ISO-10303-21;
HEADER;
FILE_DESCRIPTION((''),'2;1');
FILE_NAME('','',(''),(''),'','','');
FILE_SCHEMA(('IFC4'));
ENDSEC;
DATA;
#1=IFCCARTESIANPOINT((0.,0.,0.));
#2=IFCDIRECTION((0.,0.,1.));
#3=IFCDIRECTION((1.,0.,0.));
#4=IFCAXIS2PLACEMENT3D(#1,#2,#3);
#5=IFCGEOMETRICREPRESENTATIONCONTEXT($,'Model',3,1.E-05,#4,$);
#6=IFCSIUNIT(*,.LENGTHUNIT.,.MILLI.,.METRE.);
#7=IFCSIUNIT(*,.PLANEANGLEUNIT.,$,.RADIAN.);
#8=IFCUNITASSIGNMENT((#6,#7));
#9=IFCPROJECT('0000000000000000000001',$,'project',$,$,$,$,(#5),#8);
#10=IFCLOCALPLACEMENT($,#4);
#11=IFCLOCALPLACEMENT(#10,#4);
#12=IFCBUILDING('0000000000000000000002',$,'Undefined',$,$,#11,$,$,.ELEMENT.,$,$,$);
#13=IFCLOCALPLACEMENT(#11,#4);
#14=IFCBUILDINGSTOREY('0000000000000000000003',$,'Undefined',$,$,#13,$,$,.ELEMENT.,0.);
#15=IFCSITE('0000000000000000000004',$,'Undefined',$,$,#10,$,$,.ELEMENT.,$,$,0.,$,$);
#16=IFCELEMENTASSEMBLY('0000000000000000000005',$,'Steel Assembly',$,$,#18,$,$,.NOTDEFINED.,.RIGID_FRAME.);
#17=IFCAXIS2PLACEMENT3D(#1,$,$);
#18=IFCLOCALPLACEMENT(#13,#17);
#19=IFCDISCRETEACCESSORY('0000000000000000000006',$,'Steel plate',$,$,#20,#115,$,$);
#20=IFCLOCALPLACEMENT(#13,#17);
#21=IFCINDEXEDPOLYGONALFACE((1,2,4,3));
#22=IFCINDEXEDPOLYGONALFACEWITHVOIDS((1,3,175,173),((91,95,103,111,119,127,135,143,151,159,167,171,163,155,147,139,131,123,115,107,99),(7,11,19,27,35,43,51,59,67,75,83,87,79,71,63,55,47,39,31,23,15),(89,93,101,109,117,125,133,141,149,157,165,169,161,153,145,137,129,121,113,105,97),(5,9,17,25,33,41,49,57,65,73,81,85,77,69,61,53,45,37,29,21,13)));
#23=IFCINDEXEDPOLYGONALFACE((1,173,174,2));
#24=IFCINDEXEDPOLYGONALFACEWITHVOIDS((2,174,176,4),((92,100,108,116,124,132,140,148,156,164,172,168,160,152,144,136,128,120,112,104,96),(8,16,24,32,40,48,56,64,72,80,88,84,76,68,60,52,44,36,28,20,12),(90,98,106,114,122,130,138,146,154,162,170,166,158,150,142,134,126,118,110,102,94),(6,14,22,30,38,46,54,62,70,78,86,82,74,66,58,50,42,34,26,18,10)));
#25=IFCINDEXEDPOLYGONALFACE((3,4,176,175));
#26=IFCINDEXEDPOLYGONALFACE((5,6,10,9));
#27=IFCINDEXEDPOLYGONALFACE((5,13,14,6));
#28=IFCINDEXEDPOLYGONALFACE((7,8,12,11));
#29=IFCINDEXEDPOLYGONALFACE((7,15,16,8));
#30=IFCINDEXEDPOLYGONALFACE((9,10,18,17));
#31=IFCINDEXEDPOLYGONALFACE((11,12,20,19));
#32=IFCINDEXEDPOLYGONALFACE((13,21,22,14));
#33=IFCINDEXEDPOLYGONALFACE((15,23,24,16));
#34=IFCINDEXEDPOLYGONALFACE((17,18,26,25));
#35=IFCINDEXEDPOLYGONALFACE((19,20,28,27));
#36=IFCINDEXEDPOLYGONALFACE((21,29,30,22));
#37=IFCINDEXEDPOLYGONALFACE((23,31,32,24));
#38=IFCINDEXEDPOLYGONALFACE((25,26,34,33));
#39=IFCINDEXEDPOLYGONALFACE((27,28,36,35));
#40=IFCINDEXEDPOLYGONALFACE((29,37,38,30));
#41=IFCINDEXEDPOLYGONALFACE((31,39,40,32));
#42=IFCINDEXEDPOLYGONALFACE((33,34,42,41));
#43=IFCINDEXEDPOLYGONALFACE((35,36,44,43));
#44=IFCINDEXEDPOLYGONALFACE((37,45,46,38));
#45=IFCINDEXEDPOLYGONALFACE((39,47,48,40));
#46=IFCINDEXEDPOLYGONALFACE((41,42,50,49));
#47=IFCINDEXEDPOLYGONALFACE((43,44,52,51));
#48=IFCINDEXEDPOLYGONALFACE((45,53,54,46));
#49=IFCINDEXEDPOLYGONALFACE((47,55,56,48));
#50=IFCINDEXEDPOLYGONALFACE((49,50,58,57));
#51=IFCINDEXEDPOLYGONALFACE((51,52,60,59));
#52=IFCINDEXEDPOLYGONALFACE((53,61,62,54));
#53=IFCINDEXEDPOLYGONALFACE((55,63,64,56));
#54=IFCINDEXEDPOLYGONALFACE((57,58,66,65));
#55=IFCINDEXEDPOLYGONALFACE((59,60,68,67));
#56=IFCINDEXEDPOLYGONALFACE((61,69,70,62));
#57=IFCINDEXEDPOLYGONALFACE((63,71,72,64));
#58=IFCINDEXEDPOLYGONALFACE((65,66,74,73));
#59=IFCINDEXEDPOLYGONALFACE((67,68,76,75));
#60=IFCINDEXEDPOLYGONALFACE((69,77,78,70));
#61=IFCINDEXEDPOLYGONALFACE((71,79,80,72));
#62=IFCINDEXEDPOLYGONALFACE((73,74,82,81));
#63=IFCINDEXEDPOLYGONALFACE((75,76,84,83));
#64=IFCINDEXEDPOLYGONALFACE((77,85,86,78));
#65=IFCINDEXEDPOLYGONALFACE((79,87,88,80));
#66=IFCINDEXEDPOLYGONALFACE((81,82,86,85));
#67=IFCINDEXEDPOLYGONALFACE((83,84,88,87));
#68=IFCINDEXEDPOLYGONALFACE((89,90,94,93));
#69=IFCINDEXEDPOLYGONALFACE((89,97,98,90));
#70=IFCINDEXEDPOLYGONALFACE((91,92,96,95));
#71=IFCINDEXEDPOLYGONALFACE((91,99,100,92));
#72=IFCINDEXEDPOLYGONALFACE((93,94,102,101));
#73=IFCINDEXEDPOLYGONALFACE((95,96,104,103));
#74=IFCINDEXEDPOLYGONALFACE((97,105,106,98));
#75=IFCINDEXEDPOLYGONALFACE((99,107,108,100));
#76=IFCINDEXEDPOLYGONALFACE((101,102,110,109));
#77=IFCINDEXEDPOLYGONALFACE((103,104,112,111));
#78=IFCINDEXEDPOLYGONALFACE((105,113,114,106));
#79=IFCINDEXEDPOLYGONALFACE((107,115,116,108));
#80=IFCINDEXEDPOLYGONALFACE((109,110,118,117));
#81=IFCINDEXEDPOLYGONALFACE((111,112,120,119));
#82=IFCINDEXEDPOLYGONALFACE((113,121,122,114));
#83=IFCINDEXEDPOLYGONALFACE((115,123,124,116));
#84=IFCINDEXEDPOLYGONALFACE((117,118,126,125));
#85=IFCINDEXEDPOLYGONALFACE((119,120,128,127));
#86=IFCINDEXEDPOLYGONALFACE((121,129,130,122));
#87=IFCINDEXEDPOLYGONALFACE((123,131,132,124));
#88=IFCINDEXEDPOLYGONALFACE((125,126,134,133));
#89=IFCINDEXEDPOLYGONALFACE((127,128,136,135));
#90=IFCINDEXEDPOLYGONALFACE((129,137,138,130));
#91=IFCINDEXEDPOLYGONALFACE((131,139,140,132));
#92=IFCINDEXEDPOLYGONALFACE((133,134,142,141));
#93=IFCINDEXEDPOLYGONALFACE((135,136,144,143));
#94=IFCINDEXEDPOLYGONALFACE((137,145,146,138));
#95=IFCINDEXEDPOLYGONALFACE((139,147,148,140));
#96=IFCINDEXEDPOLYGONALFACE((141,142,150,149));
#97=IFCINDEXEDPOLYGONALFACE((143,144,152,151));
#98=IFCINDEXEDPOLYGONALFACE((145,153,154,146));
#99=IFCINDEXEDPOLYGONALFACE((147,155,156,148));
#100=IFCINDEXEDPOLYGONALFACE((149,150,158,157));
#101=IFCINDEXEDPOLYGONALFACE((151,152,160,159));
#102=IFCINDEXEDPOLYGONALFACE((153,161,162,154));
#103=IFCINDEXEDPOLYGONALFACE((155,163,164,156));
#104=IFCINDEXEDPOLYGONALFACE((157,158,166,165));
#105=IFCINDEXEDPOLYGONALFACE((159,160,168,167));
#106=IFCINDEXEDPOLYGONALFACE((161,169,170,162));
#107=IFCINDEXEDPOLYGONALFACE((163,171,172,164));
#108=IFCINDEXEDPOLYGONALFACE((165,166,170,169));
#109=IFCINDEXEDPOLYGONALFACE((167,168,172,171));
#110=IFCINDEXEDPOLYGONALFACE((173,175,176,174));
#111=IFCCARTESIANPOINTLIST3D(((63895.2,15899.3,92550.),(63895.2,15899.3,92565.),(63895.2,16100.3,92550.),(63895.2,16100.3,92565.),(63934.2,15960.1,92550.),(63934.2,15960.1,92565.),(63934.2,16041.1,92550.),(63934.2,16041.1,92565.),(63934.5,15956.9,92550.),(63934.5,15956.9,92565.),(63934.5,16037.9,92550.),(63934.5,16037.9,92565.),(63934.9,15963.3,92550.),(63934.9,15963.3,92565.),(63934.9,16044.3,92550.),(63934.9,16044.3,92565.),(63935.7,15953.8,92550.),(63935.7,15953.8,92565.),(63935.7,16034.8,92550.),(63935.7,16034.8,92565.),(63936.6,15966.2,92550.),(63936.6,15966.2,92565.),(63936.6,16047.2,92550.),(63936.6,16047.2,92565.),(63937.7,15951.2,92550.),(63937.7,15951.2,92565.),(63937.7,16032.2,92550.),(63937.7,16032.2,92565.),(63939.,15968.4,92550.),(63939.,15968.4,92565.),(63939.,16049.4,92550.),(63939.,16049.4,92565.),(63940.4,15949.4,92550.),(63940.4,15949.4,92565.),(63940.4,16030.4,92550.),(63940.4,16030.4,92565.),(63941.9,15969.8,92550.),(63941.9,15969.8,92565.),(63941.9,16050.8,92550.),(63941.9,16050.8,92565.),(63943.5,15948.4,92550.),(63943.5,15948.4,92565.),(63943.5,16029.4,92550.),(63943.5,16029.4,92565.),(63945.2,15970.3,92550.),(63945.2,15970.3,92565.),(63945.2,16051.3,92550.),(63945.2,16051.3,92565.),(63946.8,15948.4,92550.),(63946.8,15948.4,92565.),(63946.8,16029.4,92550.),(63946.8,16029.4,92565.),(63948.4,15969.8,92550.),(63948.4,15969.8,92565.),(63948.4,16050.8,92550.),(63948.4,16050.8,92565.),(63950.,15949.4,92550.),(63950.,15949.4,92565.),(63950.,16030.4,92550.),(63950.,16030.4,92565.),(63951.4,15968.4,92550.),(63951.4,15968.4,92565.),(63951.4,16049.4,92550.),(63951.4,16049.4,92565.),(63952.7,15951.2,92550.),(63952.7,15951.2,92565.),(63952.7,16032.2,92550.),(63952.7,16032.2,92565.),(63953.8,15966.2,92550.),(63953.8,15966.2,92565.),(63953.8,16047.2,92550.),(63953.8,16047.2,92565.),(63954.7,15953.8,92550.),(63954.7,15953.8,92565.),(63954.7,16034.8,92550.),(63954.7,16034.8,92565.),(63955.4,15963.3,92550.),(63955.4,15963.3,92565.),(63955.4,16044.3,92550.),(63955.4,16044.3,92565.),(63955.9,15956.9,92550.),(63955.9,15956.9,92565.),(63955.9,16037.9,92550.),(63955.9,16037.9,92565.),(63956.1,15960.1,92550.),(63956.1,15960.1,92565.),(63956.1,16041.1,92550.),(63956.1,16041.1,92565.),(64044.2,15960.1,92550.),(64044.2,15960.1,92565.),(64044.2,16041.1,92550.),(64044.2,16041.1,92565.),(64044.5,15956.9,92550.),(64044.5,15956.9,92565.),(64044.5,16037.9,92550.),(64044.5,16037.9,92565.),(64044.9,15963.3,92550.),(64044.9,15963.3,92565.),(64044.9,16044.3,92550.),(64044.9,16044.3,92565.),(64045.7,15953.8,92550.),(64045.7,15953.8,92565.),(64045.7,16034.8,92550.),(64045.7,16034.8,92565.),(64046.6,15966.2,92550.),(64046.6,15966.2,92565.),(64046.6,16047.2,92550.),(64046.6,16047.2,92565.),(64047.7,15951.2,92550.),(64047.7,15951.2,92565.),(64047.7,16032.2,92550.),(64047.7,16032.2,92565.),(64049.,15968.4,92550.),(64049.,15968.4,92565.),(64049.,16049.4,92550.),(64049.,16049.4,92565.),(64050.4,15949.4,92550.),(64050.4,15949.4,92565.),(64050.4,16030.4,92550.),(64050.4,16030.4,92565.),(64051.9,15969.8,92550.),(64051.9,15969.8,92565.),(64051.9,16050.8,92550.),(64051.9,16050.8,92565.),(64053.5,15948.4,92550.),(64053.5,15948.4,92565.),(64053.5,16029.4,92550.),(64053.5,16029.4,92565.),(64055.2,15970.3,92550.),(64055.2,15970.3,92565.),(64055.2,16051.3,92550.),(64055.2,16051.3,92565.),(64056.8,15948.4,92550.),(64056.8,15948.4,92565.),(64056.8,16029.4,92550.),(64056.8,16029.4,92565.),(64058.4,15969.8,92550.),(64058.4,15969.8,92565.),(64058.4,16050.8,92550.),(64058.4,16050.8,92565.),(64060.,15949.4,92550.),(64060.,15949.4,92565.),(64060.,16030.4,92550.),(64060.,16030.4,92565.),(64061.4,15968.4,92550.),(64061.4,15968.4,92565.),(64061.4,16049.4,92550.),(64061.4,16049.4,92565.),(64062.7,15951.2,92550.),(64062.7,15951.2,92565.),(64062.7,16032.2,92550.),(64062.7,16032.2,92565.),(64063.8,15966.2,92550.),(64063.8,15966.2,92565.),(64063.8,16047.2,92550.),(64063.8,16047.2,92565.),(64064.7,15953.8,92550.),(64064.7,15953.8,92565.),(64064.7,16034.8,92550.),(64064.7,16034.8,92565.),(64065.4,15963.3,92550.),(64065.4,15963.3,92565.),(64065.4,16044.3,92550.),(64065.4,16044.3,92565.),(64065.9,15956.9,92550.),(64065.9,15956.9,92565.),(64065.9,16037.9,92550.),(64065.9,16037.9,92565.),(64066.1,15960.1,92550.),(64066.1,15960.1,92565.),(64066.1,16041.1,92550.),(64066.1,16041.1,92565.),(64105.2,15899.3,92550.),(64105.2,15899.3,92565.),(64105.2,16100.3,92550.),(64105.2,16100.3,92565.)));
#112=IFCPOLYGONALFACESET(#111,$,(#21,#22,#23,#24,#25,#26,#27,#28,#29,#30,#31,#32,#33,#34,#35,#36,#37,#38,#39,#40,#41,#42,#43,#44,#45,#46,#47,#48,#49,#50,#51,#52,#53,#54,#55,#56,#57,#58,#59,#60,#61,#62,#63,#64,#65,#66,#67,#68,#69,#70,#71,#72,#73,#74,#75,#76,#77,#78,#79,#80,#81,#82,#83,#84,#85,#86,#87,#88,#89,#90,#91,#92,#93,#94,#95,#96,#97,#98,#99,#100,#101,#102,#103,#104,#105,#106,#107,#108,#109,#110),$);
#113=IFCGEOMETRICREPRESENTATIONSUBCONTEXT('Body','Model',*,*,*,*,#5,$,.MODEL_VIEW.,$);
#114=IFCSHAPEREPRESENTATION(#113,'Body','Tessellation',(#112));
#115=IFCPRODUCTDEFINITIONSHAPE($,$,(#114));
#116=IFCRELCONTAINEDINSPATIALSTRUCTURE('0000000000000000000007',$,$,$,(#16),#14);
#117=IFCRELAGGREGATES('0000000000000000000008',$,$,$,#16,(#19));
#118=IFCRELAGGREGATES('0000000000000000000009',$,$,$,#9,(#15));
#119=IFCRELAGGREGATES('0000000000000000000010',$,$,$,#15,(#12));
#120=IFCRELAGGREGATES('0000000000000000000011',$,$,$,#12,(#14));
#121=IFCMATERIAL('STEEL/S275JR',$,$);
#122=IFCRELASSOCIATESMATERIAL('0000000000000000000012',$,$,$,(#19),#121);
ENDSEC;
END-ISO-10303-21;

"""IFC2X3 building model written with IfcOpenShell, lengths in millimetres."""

from ifc_helpers import new_model, si_unit, frame, origin_with_axes, origin_2d_with_axis, place, context, subcontext, project, spatial, polyline, circle, outline, extrude, source, transform, mapped, material, element, aggregate, save


model = new_model("IFC2X3")

# Units and contexts
model_context = context("Model", 3, precision=1e-05, world=origin_with_axes())
body_context = subcontext(model_context, "Body", "Model", "MODEL_VIEW")
ifc_project = project(units=[si_unit("LENGTHUNIT", "METRE", prefix="MILLI"), si_unit("PLANEANGLEUNIT", "RADIAN")], contexts=[model_context])

# Site, building, storey
site_placement = place(None, origin_with_axes())
site = spatial("IfcSite", under=ifc_project, at=site_placement, Name="Undefined", CompositionType="ELEMENT", RefElevation=0.0)
building_placement = place(site_placement, origin_with_axes())
building = spatial("IfcBuilding", under=site, at=building_placement, Name="Undefined", CompositionType="ELEMENT")
storey_placement = place(building_placement, origin_with_axes())
storey = spatial("IfcBuildingStorey", under=building, at=storey_placement, Name="Undefined", CompositionType="ELEMENT", Elevation=0.0)

# Shared definitions
ifc_material_1 = material(Name="STEEL/S275JR")

# Element assembly
assembly_1_placement = place(storey_placement, origin_with_axes())
assembly_1 = element("IfcElementAssembly", 1, at=assembly_1_placement, inside=storey, Name="Steel Assembly", AssemblyPlace="NOTDEFINED", PredefinedType="RIGID_FRAME")

# Discrete accessory, opening
discrete_accessory_1_placement = place(assembly_1_placement, frame((63895.2, 16100.3, 92557.5), z_axis=(0.0, 0.0, 1.0), x_axis=(0.0, -1.0, 0.0)))
discrete_accessory_1 = element("IfcDiscreteAccessory", 2, at=discrete_accessory_1_placement, material=ifc_material_1, Name="Steel plate", context=body_context, shape_type="SweptSolid", body=[
    extrude(outline(polyline([(0.0, 0.0), (201.0, 0.0), (201.0, 210.0), (0.0, 210.0), (0.0, 0.0)])), frame((0.0, 0.0, -7.5), z_axis=(0.0, 0.0, 1.0), x_axis=(1.0, 0.0, 0.0)), (0.0, 0.0, 1.0), 15.0),
])
shared_shape_1 = source(origin_with_axes(), body_context, "Body", "SweptSolid", [
    extrude(circle(Radius=11.0, at=origin_2d_with_axis()), frame((0.0, -0.1, 0.0), z_axis=(0.0, 1.0, 0.0), x_axis=(1.0, 0.0, 0.0)), (0.0, 0.0, 1.0), 15.2),
])
opening_1_placement = place(assembly_1_placement, frame((64000.2, 15959.3, 92565.0), z_axis=(-1.0, 0.0, 0.0), x_axis=(0.0, 1.0, 0.0)))
element("IfcOpeningElement", 3, at=opening_1_placement, cuts=discrete_accessory_1, ObjectType="Opening", context=body_context, shape_type="MappedRepresentation", body=[
    mapped(shared_shape_1, transform((0.0, 0.0, -55.0))),
    mapped(shared_shape_1, transform((81.0, 0.0, -55.0))),
    mapped(shared_shape_1, transform((0.0, 0.0, 55.0))),
    mapped(shared_shape_1, transform((81.0, 0.0, 55.0))),
])
aggregate(assembly_1, [discrete_accessory_1])

save(model, "model.ifc")
